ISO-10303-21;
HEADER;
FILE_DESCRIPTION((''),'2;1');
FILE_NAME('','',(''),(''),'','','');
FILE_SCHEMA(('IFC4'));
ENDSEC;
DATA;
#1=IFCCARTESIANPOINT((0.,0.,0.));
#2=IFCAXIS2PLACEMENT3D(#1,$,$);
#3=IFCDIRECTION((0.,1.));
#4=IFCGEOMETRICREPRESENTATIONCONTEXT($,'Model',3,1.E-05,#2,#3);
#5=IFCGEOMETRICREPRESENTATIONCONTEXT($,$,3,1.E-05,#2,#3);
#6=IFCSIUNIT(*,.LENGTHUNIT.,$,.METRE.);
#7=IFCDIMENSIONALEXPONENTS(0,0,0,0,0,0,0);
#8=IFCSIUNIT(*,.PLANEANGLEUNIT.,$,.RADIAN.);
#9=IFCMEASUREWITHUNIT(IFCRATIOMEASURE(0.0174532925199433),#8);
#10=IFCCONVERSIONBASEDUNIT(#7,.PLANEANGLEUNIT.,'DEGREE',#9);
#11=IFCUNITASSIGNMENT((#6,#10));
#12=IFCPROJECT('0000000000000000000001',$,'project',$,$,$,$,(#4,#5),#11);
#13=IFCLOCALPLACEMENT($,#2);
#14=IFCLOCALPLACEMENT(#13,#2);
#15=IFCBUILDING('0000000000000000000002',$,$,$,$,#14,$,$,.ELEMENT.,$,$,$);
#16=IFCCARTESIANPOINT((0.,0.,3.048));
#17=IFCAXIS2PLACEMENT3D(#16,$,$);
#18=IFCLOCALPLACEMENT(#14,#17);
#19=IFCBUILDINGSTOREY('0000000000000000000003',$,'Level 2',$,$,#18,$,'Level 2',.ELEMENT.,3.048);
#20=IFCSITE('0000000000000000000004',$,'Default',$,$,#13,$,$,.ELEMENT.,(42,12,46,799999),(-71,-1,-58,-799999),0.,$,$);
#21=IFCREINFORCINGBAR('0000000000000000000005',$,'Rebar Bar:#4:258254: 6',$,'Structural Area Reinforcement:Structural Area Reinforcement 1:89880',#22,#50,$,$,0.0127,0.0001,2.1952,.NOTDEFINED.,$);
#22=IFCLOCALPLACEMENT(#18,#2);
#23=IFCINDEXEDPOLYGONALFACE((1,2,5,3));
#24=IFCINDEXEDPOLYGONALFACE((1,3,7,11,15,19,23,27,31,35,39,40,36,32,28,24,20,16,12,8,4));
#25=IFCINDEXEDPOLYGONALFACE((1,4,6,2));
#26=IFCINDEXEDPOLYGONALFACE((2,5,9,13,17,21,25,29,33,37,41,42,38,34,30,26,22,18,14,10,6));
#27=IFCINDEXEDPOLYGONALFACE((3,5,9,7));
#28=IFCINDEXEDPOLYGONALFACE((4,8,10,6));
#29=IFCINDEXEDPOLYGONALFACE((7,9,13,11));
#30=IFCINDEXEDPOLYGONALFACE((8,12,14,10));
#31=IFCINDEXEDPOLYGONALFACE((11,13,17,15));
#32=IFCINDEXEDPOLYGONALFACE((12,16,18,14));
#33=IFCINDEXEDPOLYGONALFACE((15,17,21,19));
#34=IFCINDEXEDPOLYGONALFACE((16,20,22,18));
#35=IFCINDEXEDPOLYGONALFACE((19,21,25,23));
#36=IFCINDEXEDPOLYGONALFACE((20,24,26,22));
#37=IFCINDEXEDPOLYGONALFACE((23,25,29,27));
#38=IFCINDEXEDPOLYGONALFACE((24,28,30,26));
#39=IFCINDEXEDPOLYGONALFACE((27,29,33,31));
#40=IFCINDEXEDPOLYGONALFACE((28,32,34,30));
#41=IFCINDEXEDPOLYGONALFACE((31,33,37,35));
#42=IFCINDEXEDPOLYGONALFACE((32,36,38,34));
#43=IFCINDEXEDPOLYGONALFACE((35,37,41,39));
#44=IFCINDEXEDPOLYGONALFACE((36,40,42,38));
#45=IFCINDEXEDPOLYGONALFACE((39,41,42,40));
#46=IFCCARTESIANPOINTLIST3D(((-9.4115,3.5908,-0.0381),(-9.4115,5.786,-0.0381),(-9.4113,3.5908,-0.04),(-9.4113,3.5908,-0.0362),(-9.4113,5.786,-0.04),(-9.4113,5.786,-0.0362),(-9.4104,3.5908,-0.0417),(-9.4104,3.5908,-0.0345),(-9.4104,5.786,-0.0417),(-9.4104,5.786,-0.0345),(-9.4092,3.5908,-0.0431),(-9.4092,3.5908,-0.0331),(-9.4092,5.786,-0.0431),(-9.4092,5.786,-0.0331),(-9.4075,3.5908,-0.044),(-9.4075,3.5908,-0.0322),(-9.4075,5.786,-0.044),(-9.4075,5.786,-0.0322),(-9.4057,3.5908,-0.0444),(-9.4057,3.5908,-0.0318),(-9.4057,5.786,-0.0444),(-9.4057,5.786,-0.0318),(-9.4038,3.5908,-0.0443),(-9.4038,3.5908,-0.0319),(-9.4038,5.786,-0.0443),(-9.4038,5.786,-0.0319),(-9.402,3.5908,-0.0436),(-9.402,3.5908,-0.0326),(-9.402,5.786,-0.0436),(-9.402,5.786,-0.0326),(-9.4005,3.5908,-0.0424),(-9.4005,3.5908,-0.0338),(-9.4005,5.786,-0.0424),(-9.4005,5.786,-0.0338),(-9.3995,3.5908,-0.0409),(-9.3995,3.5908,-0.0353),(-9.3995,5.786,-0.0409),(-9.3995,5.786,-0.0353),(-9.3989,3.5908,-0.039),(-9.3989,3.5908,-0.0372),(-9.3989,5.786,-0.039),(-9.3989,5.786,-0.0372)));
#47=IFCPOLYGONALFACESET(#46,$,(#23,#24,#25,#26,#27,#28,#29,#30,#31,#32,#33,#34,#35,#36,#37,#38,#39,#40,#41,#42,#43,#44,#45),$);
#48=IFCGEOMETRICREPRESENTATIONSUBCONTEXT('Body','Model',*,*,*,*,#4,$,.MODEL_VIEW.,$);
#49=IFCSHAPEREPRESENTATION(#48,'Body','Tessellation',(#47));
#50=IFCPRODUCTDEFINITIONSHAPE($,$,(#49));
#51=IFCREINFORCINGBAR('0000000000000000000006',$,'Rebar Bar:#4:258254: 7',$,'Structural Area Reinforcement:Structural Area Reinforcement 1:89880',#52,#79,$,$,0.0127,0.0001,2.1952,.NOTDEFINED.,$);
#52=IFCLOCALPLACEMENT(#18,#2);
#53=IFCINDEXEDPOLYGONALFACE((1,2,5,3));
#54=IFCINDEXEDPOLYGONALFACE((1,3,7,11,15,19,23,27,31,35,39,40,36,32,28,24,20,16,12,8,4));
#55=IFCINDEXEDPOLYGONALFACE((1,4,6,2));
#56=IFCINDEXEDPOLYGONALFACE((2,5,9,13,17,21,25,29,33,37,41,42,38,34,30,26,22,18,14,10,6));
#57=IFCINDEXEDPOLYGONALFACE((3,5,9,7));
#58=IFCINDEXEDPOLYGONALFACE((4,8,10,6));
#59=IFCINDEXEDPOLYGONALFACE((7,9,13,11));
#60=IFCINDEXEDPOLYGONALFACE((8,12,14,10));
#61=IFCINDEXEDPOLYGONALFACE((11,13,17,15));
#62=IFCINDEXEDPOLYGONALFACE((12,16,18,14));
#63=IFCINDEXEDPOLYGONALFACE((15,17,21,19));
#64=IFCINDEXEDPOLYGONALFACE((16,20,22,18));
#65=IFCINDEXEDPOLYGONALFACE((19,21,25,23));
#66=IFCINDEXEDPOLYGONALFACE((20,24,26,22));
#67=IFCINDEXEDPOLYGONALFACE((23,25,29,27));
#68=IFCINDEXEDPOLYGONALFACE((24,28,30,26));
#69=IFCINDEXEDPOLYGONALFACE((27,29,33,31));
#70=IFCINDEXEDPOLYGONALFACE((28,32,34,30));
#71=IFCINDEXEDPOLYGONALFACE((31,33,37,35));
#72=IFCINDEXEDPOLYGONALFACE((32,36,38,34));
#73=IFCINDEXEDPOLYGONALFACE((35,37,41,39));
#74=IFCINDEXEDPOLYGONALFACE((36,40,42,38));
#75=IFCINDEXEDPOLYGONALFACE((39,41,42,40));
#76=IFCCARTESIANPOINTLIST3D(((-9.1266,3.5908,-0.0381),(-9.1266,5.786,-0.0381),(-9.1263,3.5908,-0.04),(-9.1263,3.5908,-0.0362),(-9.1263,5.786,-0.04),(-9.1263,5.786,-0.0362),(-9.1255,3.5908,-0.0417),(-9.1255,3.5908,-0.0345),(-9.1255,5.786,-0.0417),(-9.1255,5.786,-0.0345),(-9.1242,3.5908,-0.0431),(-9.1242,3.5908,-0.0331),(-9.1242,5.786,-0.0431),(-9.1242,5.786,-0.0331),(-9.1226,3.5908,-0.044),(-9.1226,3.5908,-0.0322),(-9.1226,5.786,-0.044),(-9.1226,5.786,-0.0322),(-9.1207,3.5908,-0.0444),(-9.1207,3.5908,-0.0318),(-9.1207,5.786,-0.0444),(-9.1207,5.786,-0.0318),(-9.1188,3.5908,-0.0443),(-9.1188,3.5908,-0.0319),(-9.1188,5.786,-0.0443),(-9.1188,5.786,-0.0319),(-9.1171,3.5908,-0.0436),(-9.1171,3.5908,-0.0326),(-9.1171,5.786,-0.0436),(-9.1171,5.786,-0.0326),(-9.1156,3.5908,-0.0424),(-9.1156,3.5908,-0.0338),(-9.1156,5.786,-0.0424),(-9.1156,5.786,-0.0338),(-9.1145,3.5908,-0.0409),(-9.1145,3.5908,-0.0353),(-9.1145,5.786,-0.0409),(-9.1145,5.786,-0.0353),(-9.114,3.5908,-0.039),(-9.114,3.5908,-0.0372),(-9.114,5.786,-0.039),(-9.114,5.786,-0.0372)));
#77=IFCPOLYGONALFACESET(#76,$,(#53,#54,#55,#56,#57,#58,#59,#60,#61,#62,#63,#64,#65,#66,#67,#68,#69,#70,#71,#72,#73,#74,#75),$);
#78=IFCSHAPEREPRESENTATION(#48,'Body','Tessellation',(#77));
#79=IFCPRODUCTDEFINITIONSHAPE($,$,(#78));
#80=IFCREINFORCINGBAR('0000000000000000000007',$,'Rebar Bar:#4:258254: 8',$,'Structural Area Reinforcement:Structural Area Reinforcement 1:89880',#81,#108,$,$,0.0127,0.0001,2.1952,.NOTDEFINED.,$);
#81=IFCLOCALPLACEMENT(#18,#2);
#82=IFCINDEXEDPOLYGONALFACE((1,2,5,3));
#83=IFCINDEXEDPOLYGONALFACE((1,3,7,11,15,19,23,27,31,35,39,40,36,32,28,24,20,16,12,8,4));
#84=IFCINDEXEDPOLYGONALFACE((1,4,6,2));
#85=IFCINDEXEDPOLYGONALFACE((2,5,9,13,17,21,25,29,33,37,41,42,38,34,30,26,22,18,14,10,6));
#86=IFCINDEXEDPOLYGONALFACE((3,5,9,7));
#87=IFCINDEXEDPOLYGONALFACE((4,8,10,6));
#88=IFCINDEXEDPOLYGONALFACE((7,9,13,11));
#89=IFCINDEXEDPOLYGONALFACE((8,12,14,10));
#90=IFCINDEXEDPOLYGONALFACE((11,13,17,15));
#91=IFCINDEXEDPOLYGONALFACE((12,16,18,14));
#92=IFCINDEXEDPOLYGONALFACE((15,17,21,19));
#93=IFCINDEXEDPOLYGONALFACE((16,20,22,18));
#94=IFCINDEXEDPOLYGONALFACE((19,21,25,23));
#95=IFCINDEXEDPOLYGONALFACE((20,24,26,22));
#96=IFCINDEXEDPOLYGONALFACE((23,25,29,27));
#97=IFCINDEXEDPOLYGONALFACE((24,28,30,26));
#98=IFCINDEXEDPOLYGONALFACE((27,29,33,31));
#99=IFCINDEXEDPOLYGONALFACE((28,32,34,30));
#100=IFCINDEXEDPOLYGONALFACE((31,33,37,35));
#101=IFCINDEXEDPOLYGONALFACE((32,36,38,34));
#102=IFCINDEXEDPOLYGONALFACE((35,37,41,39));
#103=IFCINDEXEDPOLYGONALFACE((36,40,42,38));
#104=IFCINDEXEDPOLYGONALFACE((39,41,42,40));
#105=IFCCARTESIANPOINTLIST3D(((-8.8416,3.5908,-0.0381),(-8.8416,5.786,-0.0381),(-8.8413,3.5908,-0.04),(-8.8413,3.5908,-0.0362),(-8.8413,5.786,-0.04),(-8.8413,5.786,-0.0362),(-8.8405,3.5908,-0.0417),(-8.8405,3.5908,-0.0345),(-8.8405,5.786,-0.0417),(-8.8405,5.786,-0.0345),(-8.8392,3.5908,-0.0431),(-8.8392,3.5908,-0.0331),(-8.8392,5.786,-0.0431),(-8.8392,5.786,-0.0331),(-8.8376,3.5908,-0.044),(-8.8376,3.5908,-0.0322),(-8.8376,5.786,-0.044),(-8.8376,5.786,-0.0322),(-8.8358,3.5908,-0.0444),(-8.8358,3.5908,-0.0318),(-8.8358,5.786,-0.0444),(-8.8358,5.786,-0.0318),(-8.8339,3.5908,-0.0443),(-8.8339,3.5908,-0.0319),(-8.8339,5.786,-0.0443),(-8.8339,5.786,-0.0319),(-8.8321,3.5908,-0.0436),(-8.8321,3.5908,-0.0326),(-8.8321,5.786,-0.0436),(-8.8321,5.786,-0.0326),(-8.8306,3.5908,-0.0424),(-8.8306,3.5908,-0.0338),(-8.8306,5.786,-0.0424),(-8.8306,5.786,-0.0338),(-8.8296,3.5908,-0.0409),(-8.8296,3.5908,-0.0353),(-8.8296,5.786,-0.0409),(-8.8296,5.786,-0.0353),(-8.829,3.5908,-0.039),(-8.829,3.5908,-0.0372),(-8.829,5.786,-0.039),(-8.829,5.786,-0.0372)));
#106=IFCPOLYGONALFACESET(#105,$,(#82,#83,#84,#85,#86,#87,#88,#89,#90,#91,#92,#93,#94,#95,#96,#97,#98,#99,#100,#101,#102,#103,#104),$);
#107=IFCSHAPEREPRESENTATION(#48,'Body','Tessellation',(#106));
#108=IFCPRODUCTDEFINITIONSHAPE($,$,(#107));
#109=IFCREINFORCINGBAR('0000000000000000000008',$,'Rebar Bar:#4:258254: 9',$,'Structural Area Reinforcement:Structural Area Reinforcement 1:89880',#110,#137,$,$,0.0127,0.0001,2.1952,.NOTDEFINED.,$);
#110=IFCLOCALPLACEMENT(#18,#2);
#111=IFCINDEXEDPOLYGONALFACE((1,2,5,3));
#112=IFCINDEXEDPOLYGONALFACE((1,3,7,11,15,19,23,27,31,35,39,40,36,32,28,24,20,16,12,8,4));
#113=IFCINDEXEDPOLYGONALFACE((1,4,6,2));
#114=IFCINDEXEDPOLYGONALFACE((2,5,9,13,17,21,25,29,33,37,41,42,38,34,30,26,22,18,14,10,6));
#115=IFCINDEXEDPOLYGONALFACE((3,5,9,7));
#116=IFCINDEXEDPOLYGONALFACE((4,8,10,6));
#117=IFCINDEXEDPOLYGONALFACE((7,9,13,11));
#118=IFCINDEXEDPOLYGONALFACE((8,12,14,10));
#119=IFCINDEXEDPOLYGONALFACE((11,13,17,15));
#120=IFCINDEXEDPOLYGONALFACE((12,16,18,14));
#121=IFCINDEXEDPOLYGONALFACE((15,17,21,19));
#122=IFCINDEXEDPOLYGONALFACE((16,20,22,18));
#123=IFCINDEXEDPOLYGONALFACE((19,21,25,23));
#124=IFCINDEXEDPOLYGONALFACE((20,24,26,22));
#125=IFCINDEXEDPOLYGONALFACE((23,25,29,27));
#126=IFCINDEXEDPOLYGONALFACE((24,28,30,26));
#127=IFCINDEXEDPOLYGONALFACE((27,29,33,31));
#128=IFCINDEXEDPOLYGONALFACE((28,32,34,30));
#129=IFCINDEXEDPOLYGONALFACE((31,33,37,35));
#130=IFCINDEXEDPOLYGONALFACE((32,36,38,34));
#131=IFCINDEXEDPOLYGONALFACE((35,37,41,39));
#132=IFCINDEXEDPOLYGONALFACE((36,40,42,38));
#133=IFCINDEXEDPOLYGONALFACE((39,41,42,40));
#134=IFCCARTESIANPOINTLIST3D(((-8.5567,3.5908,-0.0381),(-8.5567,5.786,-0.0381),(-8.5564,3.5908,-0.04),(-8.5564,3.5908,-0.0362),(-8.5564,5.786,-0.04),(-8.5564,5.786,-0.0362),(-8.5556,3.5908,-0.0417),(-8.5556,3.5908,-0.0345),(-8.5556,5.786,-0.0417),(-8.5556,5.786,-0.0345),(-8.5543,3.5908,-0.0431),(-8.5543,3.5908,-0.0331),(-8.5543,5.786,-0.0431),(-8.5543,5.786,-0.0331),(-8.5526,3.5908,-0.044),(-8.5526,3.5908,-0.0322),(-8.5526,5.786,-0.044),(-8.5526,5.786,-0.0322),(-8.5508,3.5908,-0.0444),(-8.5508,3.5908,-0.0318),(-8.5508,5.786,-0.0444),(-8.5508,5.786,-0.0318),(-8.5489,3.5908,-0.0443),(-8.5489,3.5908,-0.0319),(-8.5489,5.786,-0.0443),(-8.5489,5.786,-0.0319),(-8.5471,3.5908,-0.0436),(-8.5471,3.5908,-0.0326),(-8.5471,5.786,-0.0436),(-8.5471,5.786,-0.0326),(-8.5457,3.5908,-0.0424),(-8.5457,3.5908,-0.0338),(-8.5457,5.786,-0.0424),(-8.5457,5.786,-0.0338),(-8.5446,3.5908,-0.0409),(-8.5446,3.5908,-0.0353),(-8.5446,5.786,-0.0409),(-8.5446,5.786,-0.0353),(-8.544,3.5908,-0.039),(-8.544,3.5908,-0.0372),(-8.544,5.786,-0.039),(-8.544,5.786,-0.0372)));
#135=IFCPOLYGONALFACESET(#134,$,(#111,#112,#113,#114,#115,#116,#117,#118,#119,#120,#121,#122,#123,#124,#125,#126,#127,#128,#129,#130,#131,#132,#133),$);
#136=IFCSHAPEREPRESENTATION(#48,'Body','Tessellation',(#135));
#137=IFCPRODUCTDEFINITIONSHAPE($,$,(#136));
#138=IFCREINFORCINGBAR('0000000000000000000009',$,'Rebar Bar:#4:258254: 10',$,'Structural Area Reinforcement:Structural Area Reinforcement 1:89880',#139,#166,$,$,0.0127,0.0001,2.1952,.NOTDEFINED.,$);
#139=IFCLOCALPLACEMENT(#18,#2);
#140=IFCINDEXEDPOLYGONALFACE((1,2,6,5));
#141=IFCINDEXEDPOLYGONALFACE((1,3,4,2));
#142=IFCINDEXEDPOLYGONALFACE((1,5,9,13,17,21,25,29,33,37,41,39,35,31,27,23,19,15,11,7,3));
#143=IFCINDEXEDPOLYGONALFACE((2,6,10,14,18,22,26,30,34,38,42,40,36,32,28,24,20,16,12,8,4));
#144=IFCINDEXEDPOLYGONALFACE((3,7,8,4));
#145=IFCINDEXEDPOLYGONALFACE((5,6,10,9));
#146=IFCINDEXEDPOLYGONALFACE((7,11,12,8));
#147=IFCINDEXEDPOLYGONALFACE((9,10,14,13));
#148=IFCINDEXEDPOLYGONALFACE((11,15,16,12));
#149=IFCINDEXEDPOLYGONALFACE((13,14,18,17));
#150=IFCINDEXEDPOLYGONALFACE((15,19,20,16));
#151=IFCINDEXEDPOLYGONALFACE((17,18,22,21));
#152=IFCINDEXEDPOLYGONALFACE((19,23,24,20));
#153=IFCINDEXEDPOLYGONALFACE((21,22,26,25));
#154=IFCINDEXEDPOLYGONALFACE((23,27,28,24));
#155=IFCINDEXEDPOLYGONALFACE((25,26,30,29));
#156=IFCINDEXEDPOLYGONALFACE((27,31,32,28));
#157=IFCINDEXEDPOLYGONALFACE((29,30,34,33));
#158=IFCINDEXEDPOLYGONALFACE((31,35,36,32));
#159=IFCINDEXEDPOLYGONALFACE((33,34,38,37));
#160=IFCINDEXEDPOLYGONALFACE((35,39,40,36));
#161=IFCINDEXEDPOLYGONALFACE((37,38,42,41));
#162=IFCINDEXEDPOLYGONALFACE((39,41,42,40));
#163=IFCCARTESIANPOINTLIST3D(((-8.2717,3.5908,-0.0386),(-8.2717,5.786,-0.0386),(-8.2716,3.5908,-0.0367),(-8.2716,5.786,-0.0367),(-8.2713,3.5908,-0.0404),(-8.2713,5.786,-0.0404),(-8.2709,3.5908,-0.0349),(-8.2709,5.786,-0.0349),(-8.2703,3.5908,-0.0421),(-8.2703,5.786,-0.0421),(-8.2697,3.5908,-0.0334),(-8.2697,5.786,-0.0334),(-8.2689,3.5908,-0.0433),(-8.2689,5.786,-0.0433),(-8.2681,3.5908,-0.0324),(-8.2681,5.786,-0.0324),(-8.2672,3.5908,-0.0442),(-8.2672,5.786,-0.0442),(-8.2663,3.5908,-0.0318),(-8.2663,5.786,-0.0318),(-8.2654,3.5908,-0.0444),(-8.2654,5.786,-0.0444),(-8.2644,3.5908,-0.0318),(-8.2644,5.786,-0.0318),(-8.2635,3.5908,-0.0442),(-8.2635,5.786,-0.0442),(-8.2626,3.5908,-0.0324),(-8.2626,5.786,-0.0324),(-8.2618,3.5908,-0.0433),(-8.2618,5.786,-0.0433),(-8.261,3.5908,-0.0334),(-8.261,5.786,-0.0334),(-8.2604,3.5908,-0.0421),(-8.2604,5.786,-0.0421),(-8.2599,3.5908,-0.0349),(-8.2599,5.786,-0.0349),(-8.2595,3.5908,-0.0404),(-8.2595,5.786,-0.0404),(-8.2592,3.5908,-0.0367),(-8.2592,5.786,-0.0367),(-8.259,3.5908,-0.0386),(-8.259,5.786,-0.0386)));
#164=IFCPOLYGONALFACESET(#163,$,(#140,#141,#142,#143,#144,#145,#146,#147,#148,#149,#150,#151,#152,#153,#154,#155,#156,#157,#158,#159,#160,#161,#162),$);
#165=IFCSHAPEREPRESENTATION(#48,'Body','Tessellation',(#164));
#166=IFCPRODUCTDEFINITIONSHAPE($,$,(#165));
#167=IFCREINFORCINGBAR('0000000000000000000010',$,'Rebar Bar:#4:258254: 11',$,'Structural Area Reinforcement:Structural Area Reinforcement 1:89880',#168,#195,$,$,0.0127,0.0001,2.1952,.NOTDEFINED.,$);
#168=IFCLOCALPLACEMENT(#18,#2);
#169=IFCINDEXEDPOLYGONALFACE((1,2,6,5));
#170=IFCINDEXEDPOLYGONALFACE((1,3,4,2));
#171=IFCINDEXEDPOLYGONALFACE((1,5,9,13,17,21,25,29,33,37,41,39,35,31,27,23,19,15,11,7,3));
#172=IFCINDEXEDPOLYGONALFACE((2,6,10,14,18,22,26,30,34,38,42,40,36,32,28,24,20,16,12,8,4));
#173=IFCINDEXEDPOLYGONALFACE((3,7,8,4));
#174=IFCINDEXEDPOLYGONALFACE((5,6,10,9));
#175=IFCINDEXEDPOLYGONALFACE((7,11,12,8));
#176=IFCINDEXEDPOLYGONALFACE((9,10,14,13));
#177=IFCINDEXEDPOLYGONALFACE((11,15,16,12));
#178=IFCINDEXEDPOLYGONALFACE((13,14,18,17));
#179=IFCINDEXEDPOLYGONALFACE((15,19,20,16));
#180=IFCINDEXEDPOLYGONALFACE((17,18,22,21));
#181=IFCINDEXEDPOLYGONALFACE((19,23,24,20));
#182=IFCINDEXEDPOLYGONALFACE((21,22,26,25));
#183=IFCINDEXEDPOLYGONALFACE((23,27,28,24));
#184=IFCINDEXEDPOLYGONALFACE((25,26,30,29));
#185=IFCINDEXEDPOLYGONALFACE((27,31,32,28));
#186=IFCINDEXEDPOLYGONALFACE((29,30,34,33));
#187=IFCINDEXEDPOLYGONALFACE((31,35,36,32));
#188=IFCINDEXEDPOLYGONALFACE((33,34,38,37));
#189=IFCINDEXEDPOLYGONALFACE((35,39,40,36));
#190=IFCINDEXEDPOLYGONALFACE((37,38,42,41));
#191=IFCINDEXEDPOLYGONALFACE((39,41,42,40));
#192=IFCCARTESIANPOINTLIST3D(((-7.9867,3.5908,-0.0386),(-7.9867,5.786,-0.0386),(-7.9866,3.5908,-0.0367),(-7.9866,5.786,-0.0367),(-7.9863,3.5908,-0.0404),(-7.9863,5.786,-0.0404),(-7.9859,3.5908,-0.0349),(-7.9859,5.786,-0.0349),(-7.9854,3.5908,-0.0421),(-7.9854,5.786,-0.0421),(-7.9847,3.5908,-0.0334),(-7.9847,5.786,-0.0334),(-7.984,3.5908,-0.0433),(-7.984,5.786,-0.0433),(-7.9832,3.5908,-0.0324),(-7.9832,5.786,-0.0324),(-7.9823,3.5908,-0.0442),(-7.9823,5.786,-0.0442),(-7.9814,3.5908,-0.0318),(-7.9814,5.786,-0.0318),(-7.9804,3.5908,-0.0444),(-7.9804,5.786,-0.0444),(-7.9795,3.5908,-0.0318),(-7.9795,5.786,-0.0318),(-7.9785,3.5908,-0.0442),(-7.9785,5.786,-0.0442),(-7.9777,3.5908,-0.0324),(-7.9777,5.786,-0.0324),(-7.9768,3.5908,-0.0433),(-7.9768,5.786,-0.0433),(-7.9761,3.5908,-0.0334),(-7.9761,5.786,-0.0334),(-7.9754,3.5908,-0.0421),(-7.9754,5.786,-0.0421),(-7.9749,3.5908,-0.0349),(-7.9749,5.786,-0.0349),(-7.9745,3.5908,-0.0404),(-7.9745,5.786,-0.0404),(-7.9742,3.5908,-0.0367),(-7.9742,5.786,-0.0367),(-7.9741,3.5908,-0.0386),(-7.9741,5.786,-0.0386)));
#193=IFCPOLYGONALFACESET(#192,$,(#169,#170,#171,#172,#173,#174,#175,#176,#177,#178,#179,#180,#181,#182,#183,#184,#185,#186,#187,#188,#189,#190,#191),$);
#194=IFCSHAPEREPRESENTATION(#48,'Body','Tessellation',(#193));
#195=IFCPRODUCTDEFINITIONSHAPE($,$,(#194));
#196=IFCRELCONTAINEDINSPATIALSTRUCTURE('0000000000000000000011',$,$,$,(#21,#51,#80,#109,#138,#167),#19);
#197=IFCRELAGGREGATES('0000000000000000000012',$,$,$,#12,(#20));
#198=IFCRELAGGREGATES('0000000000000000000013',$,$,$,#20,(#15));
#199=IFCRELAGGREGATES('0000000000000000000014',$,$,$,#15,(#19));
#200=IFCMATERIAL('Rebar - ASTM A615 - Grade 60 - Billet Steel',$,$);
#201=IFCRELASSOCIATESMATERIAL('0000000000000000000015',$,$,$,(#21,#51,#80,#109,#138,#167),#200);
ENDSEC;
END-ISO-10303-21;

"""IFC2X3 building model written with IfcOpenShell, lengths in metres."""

from ifc_helpers import new_model, entity, si_unit, converted_unit, direction, frame, origin, place, context, subcontext, project, spatial, material, element, save


model = new_model("IFC2X3")

# Units and contexts
model_context = context("Model", 3, precision=1e-05, world=origin(), true_north=direction((0.0, 1.0)))
context_of_model = context(None, 3, precision=1e-05, world=origin(), true_north=direction((0.0, 1.0)))
body_context = subcontext(model_context, "Body", "Model", "MODEL_VIEW")
ifc_project = project(units=[si_unit("LENGTHUNIT", "METRE"), converted_unit("PLANEANGLEUNIT", "DEGREE", entity("IfcRatioMeasure", 0.0174532925199433), si_unit("PLANEANGLEUNIT", "RADIAN"), dimensions=[0, 0, 0, 0, 0, 0, 0])], contexts=[model_context, context_of_model])

# Site, building, storey
site_placement = place(None, origin())
site = spatial("IfcSite", under=ifc_project, at=site_placement, Name="Default", CompositionType="ELEMENT", RefLatitude=(42, 12, 46, 799999), RefLongitude=(-71, -1, -58, -799999), RefElevation=0.0)
building_placement = place(site_placement, origin())
building = spatial("IfcBuilding", under=site, at=building_placement, CompositionType="ELEMENT")
storey_placement = place(building_placement, frame((0.0, 0.0, 3.048)))
storey = spatial("IfcBuildingStorey", under=building, at=storey_placement, Name="Level 2", LongName="Level 2", CompositionType="ELEMENT", Elevation=3.048)

# Reinforcing bars
ifc_material_1 = material(Name="Rebar - ASTM A615 - Grade 60 - Billet Steel")
reinforcing_bar_1_placement = place(storey_placement, origin())
element("IfcReinforcingBar", 1, at=reinforcing_bar_1_placement, inside=storey, material=ifc_material_1, Name="Rebar Bar:#4:258254: 6", ObjectType="Structural Area Reinforcement:Structural Area Reinforcement 1:89880", BarLength=2.1952, BarRole="NOTDEFINED", CrossSectionArea=0.0001, NominalDiameter=0.0127, context=body_context, shape_type="AdvancedSweptSolid", body=[
    entity("IfcSweptDiskSolid", entity("IfcCompositeCurve", [entity("IfcCompositeCurveSegment", "CONTINUOUS", True, entity("IfcPolyline", [entity("IfcCartesianPoint", [-9.4052, 5.786, -0.0381]), entity("IfcCartesianPoint", [-9.4052, 3.5908, -0.0381])]))], False), 0.0063, None, 0.0, 1.0),
])
reinforcing_bar_2_placement = place(storey_placement, origin())
element("IfcReinforcingBar", 2, at=reinforcing_bar_2_placement, inside=storey, material=ifc_material_1, Name="Rebar Bar:#4:258254: 7", ObjectType="Structural Area Reinforcement:Structural Area Reinforcement 1:89880", BarLength=2.1952, BarRole="NOTDEFINED", CrossSectionArea=0.0001, NominalDiameter=0.0127, context=body_context, shape_type="AdvancedSweptSolid", body=[
    entity("IfcSweptDiskSolid", entity("IfcCompositeCurve", [entity("IfcCompositeCurveSegment", "CONTINUOUS", True, entity("IfcPolyline", [entity("IfcCartesianPoint", [-9.1202, 5.786, -0.0381]), entity("IfcCartesianPoint", [-9.1202, 3.5908, -0.0381])]))], False), 0.0063, None, 0.0, 1.0),
])
reinforcing_bar_3_placement = place(storey_placement, origin())
element("IfcReinforcingBar", 3, at=reinforcing_bar_3_placement, inside=storey, material=ifc_material_1, Name="Rebar Bar:#4:258254: 8", ObjectType="Structural Area Reinforcement:Structural Area Reinforcement 1:89880", BarLength=2.1952, BarRole="NOTDEFINED", CrossSectionArea=0.0001, NominalDiameter=0.0127, context=body_context, shape_type="AdvancedSweptSolid", body=[
    entity("IfcSweptDiskSolid", entity("IfcCompositeCurve", [entity("IfcCompositeCurveSegment", "CONTINUOUS", True, entity("IfcPolyline", [entity("IfcCartesianPoint", [-8.8353, 5.786, -0.0381]), entity("IfcCartesianPoint", [-8.8353, 3.5908, -0.0381])]))], False), 0.0063, None, 0.0, 1.0),
])
reinforcing_bar_4_placement = place(storey_placement, origin())
element("IfcReinforcingBar", 4, at=reinforcing_bar_4_placement, inside=storey, material=ifc_material_1, Name="Rebar Bar:#4:258254: 9", ObjectType="Structural Area Reinforcement:Structural Area Reinforcement 1:89880", BarLength=2.1952, BarRole="NOTDEFINED", CrossSectionArea=0.0001, NominalDiameter=0.0127, context=body_context, shape_type="AdvancedSweptSolid", body=[
    entity("IfcSweptDiskSolid", entity("IfcCompositeCurve", [entity("IfcCompositeCurveSegment", "CONTINUOUS", True, entity("IfcPolyline", [entity("IfcCartesianPoint", [-8.5503, 5.786, -0.0381]), entity("IfcCartesianPoint", [-8.5503, 3.5908, -0.0381])]))], False), 0.0063, None, 0.0, 1.0),
])
reinforcing_bar_5_placement = place(storey_placement, origin())
element("IfcReinforcingBar", 5, at=reinforcing_bar_5_placement, inside=storey, material=ifc_material_1, Name="Rebar Bar:#4:258254: 10", ObjectType="Structural Area Reinforcement:Structural Area Reinforcement 1:89880", BarLength=2.1952, BarRole="NOTDEFINED", CrossSectionArea=0.0001, NominalDiameter=0.0127, context=body_context, shape_type="AdvancedSweptSolid", body=[
    entity("IfcSweptDiskSolid", entity("IfcCompositeCurve", [entity("IfcCompositeCurveSegment", "CONTINUOUS", True, entity("IfcPolyline", [entity("IfcCartesianPoint", [-8.2654, 5.786, -0.0381]), entity("IfcCartesianPoint", [-8.2654, 3.5908, -0.0381])]))], False), 0.0063, None, 0.0, 1.0),
])
reinforcing_bar_6_placement = place(storey_placement, origin())
element("IfcReinforcingBar", 6, at=reinforcing_bar_6_placement, inside=storey, material=ifc_material_1, Name="Rebar Bar:#4:258254: 11", ObjectType="Structural Area Reinforcement:Structural Area Reinforcement 1:89880", BarLength=2.1952, BarRole="NOTDEFINED", CrossSectionArea=0.0001, NominalDiameter=0.0127, context=body_context, shape_type="AdvancedSweptSolid", body=[
    entity("IfcSweptDiskSolid", entity("IfcCompositeCurve", [entity("IfcCompositeCurveSegment", "CONTINUOUS", True, entity("IfcPolyline", [entity("IfcCartesianPoint", [-7.9804, 5.786, -0.0381]), entity("IfcCartesianPoint", [-7.9804, 3.5908, -0.0381])]))], False), 0.0063, None, 0.0, 1.0),
])

save(model, "model.ifc")
